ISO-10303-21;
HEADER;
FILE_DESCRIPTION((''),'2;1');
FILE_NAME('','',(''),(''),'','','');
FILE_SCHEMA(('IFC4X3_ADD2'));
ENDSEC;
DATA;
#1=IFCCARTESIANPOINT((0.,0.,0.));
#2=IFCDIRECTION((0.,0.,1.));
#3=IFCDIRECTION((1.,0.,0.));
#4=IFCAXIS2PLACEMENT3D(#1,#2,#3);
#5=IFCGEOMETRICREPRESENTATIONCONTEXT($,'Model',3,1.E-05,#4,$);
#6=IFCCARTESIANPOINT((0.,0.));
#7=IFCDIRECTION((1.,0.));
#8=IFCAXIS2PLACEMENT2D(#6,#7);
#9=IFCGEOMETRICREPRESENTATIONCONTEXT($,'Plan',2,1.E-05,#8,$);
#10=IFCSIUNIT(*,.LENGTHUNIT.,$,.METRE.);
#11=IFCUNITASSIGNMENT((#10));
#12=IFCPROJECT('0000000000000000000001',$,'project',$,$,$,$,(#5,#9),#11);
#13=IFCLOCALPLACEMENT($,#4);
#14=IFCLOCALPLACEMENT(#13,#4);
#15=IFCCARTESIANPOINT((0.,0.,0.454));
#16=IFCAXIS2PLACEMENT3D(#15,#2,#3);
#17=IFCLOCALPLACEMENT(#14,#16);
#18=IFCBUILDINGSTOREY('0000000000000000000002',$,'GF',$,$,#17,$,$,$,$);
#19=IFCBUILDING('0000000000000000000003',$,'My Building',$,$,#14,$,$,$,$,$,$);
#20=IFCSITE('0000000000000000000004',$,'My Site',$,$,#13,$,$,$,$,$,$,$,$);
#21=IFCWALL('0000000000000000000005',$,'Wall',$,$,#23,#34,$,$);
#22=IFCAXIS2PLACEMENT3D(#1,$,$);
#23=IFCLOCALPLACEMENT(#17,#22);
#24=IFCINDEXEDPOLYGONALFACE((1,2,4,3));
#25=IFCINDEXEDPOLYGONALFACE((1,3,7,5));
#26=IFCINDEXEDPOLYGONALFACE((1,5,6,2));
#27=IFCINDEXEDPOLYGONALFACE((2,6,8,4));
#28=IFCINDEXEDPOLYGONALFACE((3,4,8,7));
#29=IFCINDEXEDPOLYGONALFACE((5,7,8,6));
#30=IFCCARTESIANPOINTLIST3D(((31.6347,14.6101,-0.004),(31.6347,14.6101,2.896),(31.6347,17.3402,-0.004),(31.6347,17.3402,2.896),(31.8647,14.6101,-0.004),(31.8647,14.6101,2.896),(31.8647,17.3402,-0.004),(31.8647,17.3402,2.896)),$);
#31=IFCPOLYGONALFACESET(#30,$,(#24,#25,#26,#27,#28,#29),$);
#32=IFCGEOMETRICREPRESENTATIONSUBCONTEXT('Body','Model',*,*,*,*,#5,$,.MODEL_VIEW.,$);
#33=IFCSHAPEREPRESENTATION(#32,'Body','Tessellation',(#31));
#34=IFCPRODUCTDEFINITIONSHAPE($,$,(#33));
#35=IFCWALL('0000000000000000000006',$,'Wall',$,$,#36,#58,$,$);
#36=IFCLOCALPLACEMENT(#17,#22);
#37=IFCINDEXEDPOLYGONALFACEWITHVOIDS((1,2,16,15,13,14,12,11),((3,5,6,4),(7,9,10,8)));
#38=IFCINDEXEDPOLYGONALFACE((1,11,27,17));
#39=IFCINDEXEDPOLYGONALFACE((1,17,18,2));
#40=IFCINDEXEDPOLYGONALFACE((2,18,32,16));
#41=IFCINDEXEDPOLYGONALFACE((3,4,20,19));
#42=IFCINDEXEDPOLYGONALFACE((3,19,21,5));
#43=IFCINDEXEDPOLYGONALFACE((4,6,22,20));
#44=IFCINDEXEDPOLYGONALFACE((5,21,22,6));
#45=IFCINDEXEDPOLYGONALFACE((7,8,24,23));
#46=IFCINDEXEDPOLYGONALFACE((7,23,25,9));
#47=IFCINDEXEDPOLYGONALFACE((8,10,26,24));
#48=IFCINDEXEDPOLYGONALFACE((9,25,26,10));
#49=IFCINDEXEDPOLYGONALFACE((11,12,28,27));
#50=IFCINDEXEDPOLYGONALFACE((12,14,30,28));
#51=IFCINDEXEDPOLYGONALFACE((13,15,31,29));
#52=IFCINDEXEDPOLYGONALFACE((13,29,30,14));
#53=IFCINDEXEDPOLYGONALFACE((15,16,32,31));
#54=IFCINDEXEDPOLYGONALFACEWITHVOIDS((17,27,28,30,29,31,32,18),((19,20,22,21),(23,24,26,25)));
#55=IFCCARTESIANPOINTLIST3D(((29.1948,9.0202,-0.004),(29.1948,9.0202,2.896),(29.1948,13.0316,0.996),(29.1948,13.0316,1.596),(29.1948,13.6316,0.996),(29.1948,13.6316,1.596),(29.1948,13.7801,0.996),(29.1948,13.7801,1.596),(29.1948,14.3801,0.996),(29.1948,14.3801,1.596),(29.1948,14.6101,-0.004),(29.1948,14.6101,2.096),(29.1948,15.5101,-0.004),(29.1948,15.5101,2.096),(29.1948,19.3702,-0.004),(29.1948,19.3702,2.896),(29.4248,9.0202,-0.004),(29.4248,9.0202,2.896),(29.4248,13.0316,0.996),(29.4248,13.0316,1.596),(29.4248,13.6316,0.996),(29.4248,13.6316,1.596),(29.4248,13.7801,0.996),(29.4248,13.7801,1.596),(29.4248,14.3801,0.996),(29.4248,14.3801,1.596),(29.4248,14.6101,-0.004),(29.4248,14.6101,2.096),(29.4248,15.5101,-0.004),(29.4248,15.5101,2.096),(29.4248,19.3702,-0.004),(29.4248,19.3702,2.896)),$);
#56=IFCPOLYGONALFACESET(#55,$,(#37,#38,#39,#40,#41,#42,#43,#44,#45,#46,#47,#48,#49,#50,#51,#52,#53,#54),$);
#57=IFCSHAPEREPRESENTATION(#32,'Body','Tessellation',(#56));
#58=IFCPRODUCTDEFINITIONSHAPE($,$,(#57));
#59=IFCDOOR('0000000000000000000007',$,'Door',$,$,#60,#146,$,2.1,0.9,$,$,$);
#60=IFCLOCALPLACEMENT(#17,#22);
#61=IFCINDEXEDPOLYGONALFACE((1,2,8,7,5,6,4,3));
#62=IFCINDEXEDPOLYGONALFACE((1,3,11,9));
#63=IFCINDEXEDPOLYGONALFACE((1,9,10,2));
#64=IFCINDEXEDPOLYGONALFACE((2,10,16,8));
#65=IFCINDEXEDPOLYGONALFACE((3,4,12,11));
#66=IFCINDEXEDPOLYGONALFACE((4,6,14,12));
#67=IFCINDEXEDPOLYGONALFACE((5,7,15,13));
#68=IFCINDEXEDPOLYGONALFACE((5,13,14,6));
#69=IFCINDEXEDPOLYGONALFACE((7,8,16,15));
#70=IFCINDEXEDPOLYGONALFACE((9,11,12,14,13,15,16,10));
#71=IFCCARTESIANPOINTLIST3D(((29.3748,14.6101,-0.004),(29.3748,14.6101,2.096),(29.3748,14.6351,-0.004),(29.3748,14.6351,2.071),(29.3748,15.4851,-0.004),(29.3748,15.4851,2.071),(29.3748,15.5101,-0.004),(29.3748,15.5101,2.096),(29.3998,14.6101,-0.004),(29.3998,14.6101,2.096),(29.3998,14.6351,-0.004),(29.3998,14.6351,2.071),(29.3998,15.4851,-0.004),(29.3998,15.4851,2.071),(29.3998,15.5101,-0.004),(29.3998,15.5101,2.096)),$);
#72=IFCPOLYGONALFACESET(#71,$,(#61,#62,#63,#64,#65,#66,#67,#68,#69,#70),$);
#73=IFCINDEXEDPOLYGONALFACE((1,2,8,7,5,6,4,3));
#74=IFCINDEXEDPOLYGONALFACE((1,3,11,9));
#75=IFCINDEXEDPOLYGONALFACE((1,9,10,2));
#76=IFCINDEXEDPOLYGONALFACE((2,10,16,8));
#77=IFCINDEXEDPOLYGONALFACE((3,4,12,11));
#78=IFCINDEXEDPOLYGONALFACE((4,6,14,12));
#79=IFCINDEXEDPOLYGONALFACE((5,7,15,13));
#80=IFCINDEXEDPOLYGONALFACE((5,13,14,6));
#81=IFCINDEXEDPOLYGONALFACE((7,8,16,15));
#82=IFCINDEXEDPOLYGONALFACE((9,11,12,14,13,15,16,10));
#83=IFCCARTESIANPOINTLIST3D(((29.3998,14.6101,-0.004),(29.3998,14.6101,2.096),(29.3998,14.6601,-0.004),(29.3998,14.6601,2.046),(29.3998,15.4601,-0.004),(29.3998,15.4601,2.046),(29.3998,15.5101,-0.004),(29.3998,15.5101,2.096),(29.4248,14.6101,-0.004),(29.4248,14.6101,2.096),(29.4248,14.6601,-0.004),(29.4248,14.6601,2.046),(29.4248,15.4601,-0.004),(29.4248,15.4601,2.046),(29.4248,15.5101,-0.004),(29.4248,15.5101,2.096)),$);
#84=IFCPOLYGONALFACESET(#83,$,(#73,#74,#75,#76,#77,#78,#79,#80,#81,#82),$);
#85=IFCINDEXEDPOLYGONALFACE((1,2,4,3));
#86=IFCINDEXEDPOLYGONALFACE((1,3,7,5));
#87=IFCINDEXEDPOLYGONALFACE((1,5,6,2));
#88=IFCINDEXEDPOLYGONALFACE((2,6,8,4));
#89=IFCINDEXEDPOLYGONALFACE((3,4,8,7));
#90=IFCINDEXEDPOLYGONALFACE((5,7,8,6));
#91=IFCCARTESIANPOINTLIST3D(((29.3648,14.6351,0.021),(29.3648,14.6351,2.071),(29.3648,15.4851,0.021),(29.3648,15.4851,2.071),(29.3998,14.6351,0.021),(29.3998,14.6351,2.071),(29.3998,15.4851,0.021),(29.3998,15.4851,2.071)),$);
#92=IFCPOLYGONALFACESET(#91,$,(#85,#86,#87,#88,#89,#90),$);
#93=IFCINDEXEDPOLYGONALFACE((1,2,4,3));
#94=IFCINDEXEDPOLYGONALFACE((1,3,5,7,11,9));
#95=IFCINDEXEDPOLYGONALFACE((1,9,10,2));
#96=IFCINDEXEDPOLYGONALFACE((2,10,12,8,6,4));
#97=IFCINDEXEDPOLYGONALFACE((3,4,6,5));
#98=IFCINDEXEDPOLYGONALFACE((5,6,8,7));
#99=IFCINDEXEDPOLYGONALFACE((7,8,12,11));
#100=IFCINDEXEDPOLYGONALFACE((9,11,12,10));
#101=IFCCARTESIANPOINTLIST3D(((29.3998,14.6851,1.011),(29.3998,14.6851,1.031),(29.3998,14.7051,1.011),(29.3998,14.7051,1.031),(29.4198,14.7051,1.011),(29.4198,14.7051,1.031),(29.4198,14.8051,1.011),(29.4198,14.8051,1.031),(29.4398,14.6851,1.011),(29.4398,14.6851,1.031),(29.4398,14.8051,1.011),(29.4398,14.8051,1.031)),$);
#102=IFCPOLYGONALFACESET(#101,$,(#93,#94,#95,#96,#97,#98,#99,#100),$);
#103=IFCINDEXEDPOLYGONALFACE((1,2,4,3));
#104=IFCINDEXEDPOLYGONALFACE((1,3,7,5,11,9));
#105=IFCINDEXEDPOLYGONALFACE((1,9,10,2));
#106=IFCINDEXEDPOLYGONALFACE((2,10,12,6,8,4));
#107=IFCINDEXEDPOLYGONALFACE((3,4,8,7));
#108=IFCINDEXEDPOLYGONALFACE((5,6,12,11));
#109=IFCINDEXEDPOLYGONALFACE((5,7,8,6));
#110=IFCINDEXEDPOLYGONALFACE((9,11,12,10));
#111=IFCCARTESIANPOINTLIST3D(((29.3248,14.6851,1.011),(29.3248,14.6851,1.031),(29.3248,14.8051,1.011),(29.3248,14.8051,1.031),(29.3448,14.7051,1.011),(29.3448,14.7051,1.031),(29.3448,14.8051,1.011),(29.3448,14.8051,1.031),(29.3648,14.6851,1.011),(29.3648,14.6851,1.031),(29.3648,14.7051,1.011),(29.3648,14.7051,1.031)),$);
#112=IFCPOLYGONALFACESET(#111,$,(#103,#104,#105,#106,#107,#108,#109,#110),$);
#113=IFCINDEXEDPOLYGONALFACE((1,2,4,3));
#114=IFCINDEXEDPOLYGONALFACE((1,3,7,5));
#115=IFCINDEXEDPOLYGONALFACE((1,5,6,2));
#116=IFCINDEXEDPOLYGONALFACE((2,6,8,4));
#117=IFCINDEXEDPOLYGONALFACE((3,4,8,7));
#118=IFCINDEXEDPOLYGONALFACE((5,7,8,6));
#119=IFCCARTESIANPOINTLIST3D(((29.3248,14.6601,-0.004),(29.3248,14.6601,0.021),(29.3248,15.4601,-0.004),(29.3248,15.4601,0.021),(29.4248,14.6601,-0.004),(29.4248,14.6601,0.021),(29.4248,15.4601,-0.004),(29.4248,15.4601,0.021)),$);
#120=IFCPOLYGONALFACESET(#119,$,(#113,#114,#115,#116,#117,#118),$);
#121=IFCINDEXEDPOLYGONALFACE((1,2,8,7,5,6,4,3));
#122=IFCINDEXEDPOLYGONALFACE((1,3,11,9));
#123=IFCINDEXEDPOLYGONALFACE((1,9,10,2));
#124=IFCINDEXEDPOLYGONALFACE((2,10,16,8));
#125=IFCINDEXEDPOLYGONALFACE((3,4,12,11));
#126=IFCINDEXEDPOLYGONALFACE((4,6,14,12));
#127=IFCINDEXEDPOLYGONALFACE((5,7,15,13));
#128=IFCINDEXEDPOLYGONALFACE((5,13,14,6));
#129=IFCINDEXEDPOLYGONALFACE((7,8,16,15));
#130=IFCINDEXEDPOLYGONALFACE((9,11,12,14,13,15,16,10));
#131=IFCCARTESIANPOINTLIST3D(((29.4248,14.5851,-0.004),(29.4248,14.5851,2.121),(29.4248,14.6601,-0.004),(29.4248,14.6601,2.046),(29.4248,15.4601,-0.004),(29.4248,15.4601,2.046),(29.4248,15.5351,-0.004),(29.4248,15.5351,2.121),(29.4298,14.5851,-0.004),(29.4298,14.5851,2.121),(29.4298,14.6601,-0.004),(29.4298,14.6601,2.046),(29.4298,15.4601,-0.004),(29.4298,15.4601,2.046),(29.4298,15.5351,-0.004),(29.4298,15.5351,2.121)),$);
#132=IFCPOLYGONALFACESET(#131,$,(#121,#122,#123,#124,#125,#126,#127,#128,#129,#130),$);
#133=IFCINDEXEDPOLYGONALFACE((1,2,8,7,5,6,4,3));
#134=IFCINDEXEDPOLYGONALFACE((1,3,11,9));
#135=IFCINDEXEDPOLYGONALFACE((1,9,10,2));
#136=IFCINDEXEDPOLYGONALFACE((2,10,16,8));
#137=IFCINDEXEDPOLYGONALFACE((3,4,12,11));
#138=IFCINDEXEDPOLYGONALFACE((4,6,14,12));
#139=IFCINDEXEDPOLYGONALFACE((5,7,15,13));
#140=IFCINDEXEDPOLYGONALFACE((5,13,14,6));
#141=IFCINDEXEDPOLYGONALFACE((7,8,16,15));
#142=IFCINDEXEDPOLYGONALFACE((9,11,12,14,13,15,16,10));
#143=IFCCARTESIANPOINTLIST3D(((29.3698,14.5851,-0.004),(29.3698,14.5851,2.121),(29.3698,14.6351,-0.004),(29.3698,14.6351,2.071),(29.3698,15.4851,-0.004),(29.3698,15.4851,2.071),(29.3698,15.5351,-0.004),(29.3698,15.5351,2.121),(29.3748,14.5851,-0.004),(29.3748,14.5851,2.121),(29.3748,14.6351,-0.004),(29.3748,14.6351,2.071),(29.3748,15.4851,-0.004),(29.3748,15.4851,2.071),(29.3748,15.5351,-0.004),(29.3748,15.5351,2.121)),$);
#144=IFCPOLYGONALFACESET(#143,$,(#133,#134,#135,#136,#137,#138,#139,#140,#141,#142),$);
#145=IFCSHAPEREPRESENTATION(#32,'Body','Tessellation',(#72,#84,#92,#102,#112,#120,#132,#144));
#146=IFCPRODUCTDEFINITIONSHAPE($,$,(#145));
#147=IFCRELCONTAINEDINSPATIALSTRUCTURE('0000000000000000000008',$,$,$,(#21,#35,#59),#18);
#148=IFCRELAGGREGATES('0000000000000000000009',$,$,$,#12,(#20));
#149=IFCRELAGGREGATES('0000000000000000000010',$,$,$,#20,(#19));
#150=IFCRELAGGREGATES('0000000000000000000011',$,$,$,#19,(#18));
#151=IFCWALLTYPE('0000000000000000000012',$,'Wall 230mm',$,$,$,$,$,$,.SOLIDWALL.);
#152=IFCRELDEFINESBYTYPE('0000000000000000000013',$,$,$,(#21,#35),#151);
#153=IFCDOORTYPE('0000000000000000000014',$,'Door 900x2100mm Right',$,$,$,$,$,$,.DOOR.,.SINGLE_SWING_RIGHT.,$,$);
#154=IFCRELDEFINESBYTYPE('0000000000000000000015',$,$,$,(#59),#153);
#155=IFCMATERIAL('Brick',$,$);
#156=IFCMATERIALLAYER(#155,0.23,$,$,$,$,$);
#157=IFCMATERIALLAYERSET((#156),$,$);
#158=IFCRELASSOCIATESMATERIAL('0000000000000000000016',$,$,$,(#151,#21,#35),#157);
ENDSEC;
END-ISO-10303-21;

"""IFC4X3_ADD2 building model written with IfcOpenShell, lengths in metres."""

from ifc_helpers import new_model, entity, si_unit, frame, origin_with_axes, origin_2d_with_axis, place, context, subcontext, project, spatial, line, indexed_curve, outline, extrude, shape, source, transform, mapped, material, layer, layer_set, layer_usage, type_object, type_shapes, element, fill, save


model = new_model("IFC4X3_ADD2")

# Units and contexts
model_context = context("Model", 3, precision=1e-05, world=origin_with_axes())
plan_context = context("Plan", 2, precision=1e-05, world=origin_2d_with_axis())
body_context_1 = subcontext(model_context, "Body", "Model", "MODEL_VIEW")
body_context_2 = subcontext(plan_context, "Body", "Plan", "PLAN_VIEW")
ifc_project = project(units=[si_unit("LENGTHUNIT", "METRE")], contexts=[model_context, plan_context])

# Site, building, storey
site_placement = place(None, origin_with_axes())
site = spatial("IfcSite", under=ifc_project, at=site_placement, Name="My Site")
building_placement = place(site_placement, origin_with_axes())
building = spatial("IfcBuilding", under=site, at=building_placement, Name="My Building")
storey_placement = place(building_placement, frame((0.0, 0.0, 0.454), z_axis=(0.0, 0.0, 1.0), x_axis=(1.0, 0.0, 0.0)))
storey = spatial("IfcBuildingStorey", under=building, at=storey_placement, Name="GF")

# Wall
ifc_material = material(Name="Brick")
ifc_layer = layer(ifc_material, 0.23)
ifc_layer_set = layer_set([ifc_layer])
ifc_layer_usage_1 = layer_usage(ifc_layer_set, "AXIS2", "POSITIVE", 0.0)
wall_type = type_object("IfcWallType", Name="Wall 230mm", PredefinedType="SOLIDWALL", material=ifc_layer_set)
wall_1_placement = place(storey_placement, frame((31.8647, 14.6101, -0.004), z_axis=(0.0, 0.0, 1.0), x_axis=(0.000001, 1.0, 0.0)))
element("IfcWall", 1, at=wall_1_placement, inside=storey, type_object=wall_type, material=ifc_layer_usage_1, Name="Wall", context=body_context_1, shape_type="SweptSolid", body=[
    extrude(outline(indexed_curve([(0.0, 0.0), (0.0, 0.23), (2.73, 0.23), (2.73, 0.0), (0.0, 0.0)], self_intersect=False)), origin_with_axes(), (0.0, 0.0, 1.0), 2.9),
])

# Wall, openings, door
ifc_layer_usage_2 = layer_usage(ifc_layer_set, "AXIS2", "POSITIVE", 0.0)
wall_2_placement = place(storey_placement, frame((29.4248, 9.0202, -0.004), z_axis=(0.0, 0.0, 1.0), x_axis=(0.000001, 1.0, 0.0)))
wall_2 = element("IfcWall", 2, at=wall_2_placement, inside=storey, type_object=wall_type, material=ifc_layer_usage_2, Name="Wall", context=body_context_1, shape_type="SweptSolid", body=[
    extrude(outline(indexed_curve([(0.0, 0.0), (0.0, 0.23), (10.35, 0.23), (10.35, 0.0), (0.0, 0.0)], self_intersect=False)), origin_with_axes(), (0.0, 0.0, 1.0), 2.9),
])
shared_shape_1 = source(origin_with_axes(), body_context_1, "Body", "SweptSolid", [
    extrude(outline(indexed_curve([(0.0, 0.0), (0.9, 0.0), (0.9, 2.1), (0.0, 2.1)], segments=[line(1, 2, 3, 4, 1)])), frame((0.0, -0.6, 0.0), z_axis=(0.0, -1.0, 0.0), x_axis=(1.0, 0.0, 0.0)), (0.0, 0.0, -1.0), 1.2),
])
opening_1_placement = place(wall_2_placement, frame((5.5899, 0.0, 0.0), z_axis=(0.0, 0.0, 1.0), x_axis=(1.0, 0.0, 0.0)))
opening_1 = element("IfcOpeningElement", 3, at=opening_1_placement, cuts=wall_2, PredefinedType="OPENING", context=body_context_1, shape_type="MappedRepresentation", body=[
    mapped(shared_shape_1, transform((0.0, 0.0, 0.0), x_axis=(1.0, 0.0, 0.0), y_axis=(0.0, 1.0, 0.0), z_axis=(0.0, 0.0, 1.0), scale=1.0)),
])
shared_shape_2 = source(origin_with_axes(), body_context_1, "Body", "SweptSolid", [
    extrude(outline(indexed_curve([(0.0, 0.0), (0.6, 0.0), (0.6, 0.6), (0.0, 0.6)], segments=[line(1, 2, 3, 4, 1)])), frame((-0.3, -0.6, 0.0), z_axis=(0.0, -1.0, 0.0), x_axis=(1.0, 0.0, 0.0)), (0.0, 0.0, -1.0), 1.2),
])
opening_2_placement = place(wall_2_placement, frame((5.0599, 0.0, 1.0), z_axis=(0.0, 0.0, 1.0), x_axis=(1.0, 0.0, 0.0)))
element("IfcOpeningElement", 4, at=opening_2_placement, cuts=wall_2, PredefinedType="OPENING", context=body_context_1, shape_type="MappedRepresentation", body=[
    mapped(shared_shape_2, transform((0.0, 0.0, 0.0), x_axis=(1.0, 0.0, 0.0), y_axis=(0.0, 1.0, 0.0), z_axis=(0.0, 0.0, 1.0), scale=1.0)),
])
opening_3_placement = place(wall_2_placement, frame((4.3114, 0.0, 1.0), z_axis=(0.0, 0.0, 1.0), x_axis=(1.0, 0.0, 0.0)))
element("IfcOpeningElement", 5, at=opening_3_placement, cuts=wall_2, PredefinedType="OPENING", context=body_context_1, shape_type="MappedRepresentation", body=[
    mapped(shared_shape_2, transform((0.0, 0.0, 0.0), x_axis=(1.0, 0.0, 0.0), y_axis=(0.0, 1.0, 0.0), z_axis=(0.0, 0.0, 1.0), scale=1.0)),
])
door_type = type_object("IfcDoorType", Name="Door 900x2100mm Right", OperationType="SINGLE_SWING_RIGHT", PredefinedType="DOOR")
shared_shape_3 = source(origin_with_axes(), body_context_1, "Body", "SweptSolid", [
    extrude(outline(indexed_curve([(0.0, 0.0), (0.0, 2.1), (0.9, 2.1), (0.9, 0.0), (0.875, 0.0), (0.875, 2.075), (0.025, 2.075), (0.025, 0.0)], segments=[line(1, 2, 3, 4, 5, 6, 7, 8, 1)])), frame((0.0, 0.025, 0.0), z_axis=(0.0, -1.0, 0.0), x_axis=(1.0, 0.0, 0.0)), (0.0, 0.0, -1.0), 0.025),
    extrude(outline(indexed_curve([(0.0, 0.0), (0.0, 2.1), (0.9, 2.1), (0.9, 0.0), (0.85, 0.0), (0.85, 2.05), (0.05, 2.05), (0.05, 0.0)], segments=[line(1, 2, 3, 4, 5, 6, 7, 8, 1)])), frame((0.0, 0.0, 0.0), z_axis=(0.0, -1.0, 0.0), x_axis=(1.0, 0.0, 0.0)), (0.0, 0.0, -1.0), 0.025),
    extrude(outline(indexed_curve([(0.0, 0.0), (0.85, 0.0), (0.85, 0.035), (0.0, 0.035)], segments=[line(1, 2, 3, 4, 1)])), frame((0.025, 0.025, 0.025), z_axis=(0.0, 0.0, 1.0), x_axis=(1.0, 0.0, 0.0)), (0.0, 0.0, 1.0), 2.05),
    extrude(outline(indexed_curve([(0.0, 0.0), (0.0, -0.04), (0.12, -0.04), (0.12, -0.02), (0.02, -0.02), (0.02, 0.0)], segments=[line(1, 2, 3, 4, 5, 6, 1)])), frame((0.075, 0.025, 1.015), z_axis=(0.0, 0.0, 1.0), x_axis=(1.0, 0.0, 0.0)), (0.0, 0.0, 1.0), 0.02),
    extrude(outline(indexed_curve([(0.0, 0.0), (0.0, 0.04), (0.12, 0.04), (0.12, 0.02), (0.02, 0.02), (0.02, 0.0)], segments=[line(1, 2, 3, 4, 5, 6, 1)])), frame((0.075, 0.06, 1.015), z_axis=(0.0, 0.0, 1.0), x_axis=(1.0, 0.0, 0.0)), (0.0, 0.0, 1.0), 0.02),
    extrude(outline(indexed_curve([(0.0, 0.0), (0.8, 0.0), (0.8, 0.1), (0.0, 0.1)], segments=[line(1, 2, 3, 4, 1)])), frame((0.05, 0.0, 0.0), z_axis=(0.0, 0.0, 1.0), x_axis=(1.0, 0.0, 0.0)), (0.0, 0.0, 1.0), 0.025),
    extrude(outline(indexed_curve([(0.0, 0.0), (0.0, 2.125), (0.95, 2.125), (0.95, 0.0), (0.875, 0.0), (0.875, 2.05), (0.075, 2.05), (0.075, 0.0)], segments=[line(1, 2, 3, 4, 5, 6, 7, 8, 1)])), frame((-0.025, -0.005, 0.0), z_axis=(0.0, -1.0, 0.0), x_axis=(1.0, 0.0, 0.0)), (0.0, 0.0, -1.0), 0.005),
    extrude(outline(indexed_curve([(0.0, 0.0), (0.0, 2.125), (0.95, 2.125), (0.95, 0.0), (0.9, 0.0), (0.9, 2.075), (0.05, 2.075), (0.05, 0.0)], segments=[line(1, 2, 3, 4, 5, 6, 7, 8, 1)])), frame((-0.025, 0.05, 0.0), z_axis=(0.0, -1.0, 0.0), x_axis=(1.0, 0.0, 0.0)), (0.0, 0.0, -1.0), 0.005),
])
shared_shape_4 = source(origin_with_axes(), body_context_2, "Body", "Curve2D", [
    entity("IfcIndexedPolyCurve", entity("IfcCartesianPointList2D", [[0.0, 0.0], [0.0, 0.05], [0.025, 0.05], [0.025, 0.025], [0.05, 0.025], [0.05, 0.0]]), [entity("IfcLineIndex", [1, 2, 3, 4, 5, 6, 1])]),
    entity("IfcIndexedPolyCurve", entity("IfcCartesianPointList2D", [[0.9, 0.0], [0.9, 0.05], [0.875, 0.05], [0.875, 0.025], [0.85, 0.025], [0.85, 0.0]]), [entity("IfcLineIndex", [1, 2, 3, 4, 5, 6, 1])]),
    entity("IfcTrimmedCurve", entity("IfcEllipse", entity("IfcAxis2Placement2D", entity("IfcCartesianPoint", [0.84, 0.05]), entity("IfcDirection", [1.0, 0.0])), 0.815, 0.85), [entity("IfcCartesianPoint", [0.84, 0.9])], [entity("IfcCartesianPoint", [0.025, 0.05])], True, "CARTESIAN"),
    entity("IfcIndexedPolyCurve", entity("IfcCartesianPointList2D", [[0.875, 0.05], [0.84, 0.05], [0.84, 0.9], [0.875, 0.9]]), [entity("IfcLineIndex", [1, 2, 3, 4, 1])]),
])
type_shapes(door_type, [shared_shape_3, shared_shape_4])
door_placement = place(opening_1_placement, frame((0.0, 0.0, 0.0), z_axis=(0.0, 0.0, 1.0), x_axis=(1.0, 0.0, 0.0)))
door = element("IfcDoor", 6, at=door_placement, inside=storey, type_object=door_type, Name="Door", OverallHeight=2.1, OverallWidth=0.9, shapes=[
    shape(body_context_1, "Body", "MappedRepresentation", [mapped(shared_shape_3, transform((0.0, 0.0, 0.0), x_axis=(1.0, 0.0, 0.0), y_axis=(0.0, 1.0, 0.0), z_axis=(0.0, 0.0, 1.0), scale=1.0))]),
    shape(body_context_2, "Body", "MappedRepresentation", [mapped(shared_shape_4, transform((0.0, 0.0, 0.0), x_axis=(1.0, 0.0, 0.0), y_axis=(0.0, 1.0, 0.0), z_axis=(0.0, 0.0, 1.0), scale=1.0))]),
])
fill(opening_1, door)

save(model, "model.ifc")
